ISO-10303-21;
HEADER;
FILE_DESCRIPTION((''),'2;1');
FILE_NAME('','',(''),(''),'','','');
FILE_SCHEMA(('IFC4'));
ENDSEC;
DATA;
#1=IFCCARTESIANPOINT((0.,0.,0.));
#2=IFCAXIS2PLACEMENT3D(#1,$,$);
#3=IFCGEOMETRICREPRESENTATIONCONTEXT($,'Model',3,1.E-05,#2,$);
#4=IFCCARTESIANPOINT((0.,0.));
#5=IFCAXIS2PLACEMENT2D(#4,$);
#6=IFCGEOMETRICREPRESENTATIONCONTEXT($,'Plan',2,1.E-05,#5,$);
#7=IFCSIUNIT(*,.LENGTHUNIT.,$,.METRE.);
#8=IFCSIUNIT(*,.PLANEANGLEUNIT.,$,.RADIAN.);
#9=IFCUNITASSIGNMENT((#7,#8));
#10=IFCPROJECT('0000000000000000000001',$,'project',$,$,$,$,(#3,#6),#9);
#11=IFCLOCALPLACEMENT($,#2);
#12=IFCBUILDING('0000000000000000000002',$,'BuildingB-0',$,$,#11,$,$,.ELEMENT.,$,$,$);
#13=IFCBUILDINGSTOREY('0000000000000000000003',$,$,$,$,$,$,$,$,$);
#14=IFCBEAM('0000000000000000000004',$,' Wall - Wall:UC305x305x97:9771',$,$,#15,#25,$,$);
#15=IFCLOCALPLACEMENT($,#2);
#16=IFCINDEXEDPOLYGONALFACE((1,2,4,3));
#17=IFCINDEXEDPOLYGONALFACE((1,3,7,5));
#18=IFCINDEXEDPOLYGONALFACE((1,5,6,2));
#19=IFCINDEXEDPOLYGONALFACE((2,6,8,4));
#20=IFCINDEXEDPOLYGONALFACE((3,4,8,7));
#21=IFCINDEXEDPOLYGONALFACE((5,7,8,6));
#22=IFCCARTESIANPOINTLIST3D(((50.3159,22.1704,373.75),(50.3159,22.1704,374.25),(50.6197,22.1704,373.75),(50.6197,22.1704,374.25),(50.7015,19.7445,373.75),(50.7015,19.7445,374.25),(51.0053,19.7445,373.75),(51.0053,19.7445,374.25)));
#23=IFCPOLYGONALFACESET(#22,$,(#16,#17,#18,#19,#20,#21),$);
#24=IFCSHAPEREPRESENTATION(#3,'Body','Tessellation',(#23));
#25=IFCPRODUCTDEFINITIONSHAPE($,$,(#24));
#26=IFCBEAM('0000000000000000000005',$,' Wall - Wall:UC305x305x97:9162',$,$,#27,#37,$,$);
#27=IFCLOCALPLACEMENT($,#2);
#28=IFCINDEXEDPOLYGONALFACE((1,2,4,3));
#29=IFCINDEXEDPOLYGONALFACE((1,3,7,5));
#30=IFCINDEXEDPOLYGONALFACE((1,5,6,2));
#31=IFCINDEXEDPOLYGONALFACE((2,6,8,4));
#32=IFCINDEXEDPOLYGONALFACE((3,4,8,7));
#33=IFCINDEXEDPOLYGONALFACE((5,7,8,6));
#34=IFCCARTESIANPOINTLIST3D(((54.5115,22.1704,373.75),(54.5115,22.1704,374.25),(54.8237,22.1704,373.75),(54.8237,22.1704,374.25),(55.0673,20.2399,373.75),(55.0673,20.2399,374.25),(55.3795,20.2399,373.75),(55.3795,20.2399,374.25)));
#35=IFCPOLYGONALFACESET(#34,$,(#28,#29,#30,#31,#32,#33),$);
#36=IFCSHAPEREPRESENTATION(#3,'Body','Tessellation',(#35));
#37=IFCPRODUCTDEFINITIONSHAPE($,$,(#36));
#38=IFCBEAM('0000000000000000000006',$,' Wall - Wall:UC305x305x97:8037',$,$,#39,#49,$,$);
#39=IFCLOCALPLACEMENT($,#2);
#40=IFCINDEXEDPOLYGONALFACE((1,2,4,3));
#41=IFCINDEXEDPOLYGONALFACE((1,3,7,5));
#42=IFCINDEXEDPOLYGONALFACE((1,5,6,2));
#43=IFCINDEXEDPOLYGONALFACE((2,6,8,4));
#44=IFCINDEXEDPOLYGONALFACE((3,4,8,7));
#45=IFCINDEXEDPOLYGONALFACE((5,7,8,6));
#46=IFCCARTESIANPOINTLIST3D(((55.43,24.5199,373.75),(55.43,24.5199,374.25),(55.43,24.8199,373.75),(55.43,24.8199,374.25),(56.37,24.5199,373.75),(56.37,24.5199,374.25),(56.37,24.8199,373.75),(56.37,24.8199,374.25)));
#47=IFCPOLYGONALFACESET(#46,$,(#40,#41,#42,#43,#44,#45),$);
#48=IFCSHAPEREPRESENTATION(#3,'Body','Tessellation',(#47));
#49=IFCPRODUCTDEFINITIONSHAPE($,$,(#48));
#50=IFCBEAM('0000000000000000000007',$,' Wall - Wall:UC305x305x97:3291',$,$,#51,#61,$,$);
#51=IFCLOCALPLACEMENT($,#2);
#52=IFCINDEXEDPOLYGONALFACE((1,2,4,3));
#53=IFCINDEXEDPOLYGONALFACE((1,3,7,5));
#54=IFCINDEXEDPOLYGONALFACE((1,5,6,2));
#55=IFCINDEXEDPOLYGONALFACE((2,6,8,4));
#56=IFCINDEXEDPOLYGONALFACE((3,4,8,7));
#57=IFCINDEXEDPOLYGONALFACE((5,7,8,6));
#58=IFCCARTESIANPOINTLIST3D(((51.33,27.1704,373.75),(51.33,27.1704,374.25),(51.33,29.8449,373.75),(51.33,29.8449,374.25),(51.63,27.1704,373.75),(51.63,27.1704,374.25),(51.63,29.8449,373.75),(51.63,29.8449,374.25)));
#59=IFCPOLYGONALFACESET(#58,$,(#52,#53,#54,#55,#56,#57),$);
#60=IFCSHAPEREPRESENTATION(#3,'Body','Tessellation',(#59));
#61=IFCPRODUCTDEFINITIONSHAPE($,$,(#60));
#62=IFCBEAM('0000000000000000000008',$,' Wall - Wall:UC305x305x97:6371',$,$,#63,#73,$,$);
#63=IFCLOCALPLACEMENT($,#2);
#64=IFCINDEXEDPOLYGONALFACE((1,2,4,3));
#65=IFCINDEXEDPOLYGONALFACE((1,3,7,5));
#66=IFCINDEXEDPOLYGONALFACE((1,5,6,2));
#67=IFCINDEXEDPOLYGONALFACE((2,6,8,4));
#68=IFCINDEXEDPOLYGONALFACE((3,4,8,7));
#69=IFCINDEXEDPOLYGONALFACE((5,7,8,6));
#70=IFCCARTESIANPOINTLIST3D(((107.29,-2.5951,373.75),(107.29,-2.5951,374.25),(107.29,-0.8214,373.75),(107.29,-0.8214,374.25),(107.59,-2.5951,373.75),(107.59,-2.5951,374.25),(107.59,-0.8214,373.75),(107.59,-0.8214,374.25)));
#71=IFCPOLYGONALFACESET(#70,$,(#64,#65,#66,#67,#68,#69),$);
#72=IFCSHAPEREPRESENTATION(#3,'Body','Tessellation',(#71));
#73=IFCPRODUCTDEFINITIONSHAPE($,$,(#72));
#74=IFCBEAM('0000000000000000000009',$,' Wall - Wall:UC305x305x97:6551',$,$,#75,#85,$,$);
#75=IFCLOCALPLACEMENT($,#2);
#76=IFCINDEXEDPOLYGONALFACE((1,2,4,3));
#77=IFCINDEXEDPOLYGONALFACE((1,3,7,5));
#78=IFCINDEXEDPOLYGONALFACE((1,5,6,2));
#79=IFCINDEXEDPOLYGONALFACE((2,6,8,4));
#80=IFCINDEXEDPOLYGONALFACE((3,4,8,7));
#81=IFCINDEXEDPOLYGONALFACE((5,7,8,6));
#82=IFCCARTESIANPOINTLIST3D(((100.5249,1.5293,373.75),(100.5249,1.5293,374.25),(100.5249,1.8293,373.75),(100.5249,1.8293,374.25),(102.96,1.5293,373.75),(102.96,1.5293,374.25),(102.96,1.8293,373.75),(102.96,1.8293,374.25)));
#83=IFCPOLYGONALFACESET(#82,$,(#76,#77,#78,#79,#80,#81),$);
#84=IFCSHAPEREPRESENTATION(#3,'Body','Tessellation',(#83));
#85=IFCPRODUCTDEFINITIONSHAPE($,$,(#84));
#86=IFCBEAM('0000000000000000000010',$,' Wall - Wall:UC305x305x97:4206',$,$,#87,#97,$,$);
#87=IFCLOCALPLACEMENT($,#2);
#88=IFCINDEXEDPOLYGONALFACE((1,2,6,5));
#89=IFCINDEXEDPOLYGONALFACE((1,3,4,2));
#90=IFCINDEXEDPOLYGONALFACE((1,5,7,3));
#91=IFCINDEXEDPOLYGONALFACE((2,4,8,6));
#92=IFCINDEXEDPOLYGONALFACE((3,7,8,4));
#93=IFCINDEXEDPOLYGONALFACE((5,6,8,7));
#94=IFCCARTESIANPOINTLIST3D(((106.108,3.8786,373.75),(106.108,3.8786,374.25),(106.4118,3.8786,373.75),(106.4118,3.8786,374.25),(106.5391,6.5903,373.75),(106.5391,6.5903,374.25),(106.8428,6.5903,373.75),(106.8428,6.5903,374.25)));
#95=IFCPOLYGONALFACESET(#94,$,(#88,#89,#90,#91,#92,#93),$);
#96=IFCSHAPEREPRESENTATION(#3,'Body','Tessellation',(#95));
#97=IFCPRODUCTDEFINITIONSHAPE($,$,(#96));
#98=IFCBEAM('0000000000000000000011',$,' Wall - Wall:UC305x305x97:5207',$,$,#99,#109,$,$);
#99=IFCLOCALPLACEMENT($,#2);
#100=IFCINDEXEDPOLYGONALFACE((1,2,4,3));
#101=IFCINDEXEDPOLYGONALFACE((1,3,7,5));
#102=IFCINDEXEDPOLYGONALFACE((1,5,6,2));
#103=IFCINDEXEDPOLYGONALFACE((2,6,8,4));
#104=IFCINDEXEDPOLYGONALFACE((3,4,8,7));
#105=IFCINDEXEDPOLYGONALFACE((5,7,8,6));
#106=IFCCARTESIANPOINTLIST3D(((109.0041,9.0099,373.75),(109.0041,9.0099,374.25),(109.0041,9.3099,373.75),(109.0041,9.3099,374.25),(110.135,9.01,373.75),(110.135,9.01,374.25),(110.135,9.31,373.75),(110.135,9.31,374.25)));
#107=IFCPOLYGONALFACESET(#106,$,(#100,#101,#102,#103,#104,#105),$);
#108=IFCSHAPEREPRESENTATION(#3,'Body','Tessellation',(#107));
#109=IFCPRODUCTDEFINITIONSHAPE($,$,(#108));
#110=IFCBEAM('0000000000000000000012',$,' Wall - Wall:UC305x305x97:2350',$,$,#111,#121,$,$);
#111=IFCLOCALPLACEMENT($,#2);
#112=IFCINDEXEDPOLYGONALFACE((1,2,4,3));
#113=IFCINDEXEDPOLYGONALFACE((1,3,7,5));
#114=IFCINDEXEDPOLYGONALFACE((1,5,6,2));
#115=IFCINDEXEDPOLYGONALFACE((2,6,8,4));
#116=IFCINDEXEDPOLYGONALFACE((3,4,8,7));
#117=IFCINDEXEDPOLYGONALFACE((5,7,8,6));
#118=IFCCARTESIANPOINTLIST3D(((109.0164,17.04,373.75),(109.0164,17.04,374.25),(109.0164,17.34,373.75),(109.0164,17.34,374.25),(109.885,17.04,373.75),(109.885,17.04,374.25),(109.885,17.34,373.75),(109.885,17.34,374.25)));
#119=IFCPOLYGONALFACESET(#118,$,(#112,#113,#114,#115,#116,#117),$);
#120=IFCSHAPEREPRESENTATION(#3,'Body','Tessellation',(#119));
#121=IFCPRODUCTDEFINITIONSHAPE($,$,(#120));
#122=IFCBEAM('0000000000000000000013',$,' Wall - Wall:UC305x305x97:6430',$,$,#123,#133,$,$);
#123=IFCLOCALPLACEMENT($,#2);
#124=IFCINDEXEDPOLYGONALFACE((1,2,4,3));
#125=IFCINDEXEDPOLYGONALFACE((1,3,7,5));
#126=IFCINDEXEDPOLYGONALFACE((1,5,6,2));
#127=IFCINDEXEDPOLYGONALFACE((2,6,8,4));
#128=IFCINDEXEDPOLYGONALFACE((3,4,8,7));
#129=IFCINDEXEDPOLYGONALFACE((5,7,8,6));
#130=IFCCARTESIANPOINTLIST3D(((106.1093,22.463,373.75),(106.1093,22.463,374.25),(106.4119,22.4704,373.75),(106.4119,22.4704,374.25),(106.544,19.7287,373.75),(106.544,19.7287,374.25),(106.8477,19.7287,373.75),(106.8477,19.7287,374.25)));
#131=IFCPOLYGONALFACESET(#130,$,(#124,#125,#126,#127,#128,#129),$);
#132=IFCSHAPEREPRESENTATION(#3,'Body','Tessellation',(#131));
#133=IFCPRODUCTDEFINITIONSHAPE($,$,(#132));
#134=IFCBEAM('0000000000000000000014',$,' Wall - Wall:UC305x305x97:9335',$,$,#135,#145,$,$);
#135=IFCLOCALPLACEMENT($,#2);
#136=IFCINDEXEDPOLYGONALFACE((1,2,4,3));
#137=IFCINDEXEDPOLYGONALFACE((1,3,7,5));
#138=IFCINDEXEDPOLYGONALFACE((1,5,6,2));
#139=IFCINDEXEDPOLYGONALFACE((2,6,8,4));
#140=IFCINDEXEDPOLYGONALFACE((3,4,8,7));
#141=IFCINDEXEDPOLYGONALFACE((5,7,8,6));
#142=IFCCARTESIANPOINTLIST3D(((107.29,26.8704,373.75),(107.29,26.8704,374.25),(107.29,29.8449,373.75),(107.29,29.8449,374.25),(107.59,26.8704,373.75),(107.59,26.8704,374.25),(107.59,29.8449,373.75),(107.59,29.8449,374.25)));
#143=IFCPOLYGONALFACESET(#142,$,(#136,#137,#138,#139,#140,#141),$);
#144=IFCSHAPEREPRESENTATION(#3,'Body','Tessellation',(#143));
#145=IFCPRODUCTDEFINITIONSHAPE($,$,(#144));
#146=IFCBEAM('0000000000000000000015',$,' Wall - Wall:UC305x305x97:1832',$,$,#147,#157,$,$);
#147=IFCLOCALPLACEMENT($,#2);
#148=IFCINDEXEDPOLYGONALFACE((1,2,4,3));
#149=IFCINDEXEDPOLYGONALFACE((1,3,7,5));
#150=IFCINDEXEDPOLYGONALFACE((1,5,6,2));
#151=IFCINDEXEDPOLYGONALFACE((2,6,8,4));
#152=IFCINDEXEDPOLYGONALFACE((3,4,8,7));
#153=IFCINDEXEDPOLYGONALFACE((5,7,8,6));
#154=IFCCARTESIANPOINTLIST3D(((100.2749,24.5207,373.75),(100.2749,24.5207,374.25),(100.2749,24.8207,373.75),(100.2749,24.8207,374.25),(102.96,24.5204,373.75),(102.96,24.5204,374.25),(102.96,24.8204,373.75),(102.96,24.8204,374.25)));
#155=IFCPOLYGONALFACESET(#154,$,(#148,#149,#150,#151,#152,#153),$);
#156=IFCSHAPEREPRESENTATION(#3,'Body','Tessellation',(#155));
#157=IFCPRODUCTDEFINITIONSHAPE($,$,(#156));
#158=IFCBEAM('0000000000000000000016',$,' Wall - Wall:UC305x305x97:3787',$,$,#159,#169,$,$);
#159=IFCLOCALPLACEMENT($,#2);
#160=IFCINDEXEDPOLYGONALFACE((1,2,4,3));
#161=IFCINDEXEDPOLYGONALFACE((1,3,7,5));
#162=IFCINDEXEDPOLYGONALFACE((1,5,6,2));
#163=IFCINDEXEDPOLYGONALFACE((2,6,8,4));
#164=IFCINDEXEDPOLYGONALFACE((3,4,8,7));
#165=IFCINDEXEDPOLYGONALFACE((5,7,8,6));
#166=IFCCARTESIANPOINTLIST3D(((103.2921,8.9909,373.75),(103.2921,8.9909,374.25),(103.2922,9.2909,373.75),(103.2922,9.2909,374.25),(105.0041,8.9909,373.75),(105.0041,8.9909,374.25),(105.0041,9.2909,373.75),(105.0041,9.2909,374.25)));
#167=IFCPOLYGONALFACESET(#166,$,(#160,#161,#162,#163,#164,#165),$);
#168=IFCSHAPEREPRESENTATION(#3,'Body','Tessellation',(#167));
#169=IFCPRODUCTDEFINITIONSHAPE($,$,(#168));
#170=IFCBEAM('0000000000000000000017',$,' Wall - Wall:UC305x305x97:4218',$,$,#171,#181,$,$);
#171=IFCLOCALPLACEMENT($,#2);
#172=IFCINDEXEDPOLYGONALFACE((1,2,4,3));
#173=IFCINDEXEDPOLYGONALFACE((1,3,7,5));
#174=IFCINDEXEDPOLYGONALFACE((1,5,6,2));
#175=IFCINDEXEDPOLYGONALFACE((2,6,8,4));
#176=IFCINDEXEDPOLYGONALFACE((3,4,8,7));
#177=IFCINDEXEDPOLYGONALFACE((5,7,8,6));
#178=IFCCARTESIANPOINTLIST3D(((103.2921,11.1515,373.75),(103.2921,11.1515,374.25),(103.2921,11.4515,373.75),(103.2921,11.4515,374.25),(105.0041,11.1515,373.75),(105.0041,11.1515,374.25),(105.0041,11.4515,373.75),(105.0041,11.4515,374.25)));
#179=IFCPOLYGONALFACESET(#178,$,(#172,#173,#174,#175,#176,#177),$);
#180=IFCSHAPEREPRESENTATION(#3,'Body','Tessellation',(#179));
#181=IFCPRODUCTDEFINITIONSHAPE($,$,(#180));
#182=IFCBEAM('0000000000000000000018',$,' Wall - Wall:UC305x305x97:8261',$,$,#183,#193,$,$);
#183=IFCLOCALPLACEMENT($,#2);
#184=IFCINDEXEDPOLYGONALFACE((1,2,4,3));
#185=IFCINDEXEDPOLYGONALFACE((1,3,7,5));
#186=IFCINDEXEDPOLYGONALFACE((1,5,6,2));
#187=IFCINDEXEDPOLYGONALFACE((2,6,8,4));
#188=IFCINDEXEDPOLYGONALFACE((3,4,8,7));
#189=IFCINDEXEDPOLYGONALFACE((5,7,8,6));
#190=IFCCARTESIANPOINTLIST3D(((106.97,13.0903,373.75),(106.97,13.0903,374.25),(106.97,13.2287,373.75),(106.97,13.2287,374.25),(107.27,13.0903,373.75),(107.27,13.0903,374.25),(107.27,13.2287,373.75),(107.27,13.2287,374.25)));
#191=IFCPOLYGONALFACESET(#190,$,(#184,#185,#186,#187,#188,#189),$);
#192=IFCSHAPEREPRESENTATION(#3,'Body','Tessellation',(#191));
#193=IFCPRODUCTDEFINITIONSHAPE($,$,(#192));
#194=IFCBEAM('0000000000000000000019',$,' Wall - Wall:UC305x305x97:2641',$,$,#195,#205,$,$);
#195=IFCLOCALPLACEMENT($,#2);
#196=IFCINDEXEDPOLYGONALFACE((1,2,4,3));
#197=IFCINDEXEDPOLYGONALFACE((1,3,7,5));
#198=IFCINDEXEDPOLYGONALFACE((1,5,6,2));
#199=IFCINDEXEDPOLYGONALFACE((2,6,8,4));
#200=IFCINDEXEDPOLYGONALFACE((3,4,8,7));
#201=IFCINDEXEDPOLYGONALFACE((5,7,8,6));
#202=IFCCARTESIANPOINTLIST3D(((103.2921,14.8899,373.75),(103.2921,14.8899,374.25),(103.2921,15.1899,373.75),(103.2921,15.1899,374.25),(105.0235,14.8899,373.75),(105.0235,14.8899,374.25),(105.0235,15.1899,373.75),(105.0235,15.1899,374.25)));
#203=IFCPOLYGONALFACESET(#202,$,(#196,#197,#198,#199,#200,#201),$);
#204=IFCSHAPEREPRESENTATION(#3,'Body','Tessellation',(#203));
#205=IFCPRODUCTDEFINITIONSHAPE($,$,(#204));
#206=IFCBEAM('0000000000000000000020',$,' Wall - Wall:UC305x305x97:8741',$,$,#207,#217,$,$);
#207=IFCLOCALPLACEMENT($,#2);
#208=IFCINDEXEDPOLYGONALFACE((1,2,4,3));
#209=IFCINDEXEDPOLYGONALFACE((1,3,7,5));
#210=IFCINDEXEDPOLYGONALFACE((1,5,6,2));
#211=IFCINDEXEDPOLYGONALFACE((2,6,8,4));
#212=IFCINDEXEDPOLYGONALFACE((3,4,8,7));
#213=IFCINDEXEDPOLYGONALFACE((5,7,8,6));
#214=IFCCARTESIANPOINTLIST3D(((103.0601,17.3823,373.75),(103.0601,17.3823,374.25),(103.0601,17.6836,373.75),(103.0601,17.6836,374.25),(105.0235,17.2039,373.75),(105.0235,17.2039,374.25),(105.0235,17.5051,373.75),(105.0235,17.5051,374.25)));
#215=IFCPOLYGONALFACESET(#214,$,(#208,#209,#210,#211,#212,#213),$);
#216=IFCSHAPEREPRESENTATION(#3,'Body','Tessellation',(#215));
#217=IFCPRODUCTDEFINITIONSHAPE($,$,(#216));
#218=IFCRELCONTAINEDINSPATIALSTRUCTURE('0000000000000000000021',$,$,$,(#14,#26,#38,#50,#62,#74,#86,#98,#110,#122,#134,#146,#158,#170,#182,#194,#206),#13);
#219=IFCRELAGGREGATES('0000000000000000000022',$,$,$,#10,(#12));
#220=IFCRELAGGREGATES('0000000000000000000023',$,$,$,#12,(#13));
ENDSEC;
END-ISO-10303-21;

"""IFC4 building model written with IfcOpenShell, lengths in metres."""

from ifc_helpers import new_model, si_unit, origin, origin_2d, place, context, project, spatial, polyline, outline, extrude, element, save


model = new_model("IFC4")

# Units and contexts
model_context = context("Model", 3, precision=1e-05, world=origin())
plan_context = context("Plan", 2, precision=1e-05, world=origin_2d())
ifc_project = project(units=[si_unit("LENGTHUNIT", "METRE"), si_unit("PLANEANGLEUNIT", "RADIAN")], contexts=[model_context, plan_context])

# Building, storey
building_placement = place(None, origin())
building = spatial("IfcBuilding", under=ifc_project, at=building_placement, Name="BuildingB-0", CompositionType="ELEMENT")
storey = spatial("IfcBuildingStorey", under=building)

# Beams
element("IfcBeam", 1, inside=storey, Name=" Wall - Wall:UC305x305x97:9771", context=model_context, shape_type="SweptSolid", body=[
    extrude(outline(polyline([(50.7015, 19.7445, 373.75), (51.0053, 19.7445, 373.75), (50.6197, 22.1704, 373.75), (50.3159, 22.1704, 373.75), (50.7015, 19.7445, 373.75)])), None, (0.0, 0.0, 1.0), 0.5),
])
element("IfcBeam", 2, inside=storey, Name=" Wall - Wall:UC305x305x97:9162", context=model_context, shape_type="SweptSolid", body=[
    extrude(outline(polyline([(55.0673, 20.2399, 373.75), (55.3795, 20.2399, 373.75), (54.8237, 22.1704, 373.75), (54.5115, 22.1704, 373.75), (55.0673, 20.2399, 373.75)])), None, (0.0, 0.0, 1.0), 0.5),
])
element("IfcBeam", 3, inside=storey, Name=" Wall - Wall:UC305x305x97:8037", context=model_context, shape_type="SweptSolid", body=[
    extrude(outline(polyline([(55.43, 24.5199, 373.75), (55.43, 24.8199, 373.75), (56.37, 24.8199, 373.75), (56.37, 24.5199, 373.75), (55.43, 24.5199, 373.75)])), None, (0.0, 0.0, 1.0), 0.5),
])
element("IfcBeam", 4, inside=storey, Name=" Wall - Wall:UC305x305x97:3291", context=model_context, shape_type="SweptSolid", body=[
    extrude(outline(polyline([(51.33, 27.1704, 373.75), (51.63, 27.1704, 373.75), (51.63, 29.8449, 373.75), (51.33, 29.8449, 373.75), (51.33, 27.1704, 373.75)])), None, (0.0, 0.0, 1.0), 0.5),
])
element("IfcBeam", 5, inside=storey, Name=" Wall - Wall:UC305x305x97:6371", context=model_context, shape_type="SweptSolid", body=[
    extrude(outline(polyline([(107.59, -2.5951, 373.75), (107.29, -2.5951, 373.75), (107.29, -0.8214, 373.75), (107.59, -0.8214, 373.75), (107.59, -2.5951, 373.75)])), None, (0.0, 0.0, 1.0), 0.5),
])
element("IfcBeam", 6, inside=storey, Name=" Wall - Wall:UC305x305x97:6551", context=model_context, shape_type="SweptSolid", body=[
    extrude(outline(polyline([(102.96, 1.5293, 373.75), (102.96, 1.8293, 373.75), (100.5249, 1.8293, 373.75), (100.5249, 1.5293, 373.75), (102.96, 1.5293, 373.75)])), None, (0.0, 0.0, 1.0), 0.5),
])
element("IfcBeam", 7, inside=storey, Name=" Wall - Wall:UC305x305x97:4206", context=model_context, shape_type="SweptSolid", body=[
    extrude(outline(polyline([(106.4118, 3.8786, 373.75), (106.8428, 6.5903, 373.75), (106.5391, 6.5903, 373.75), (106.108, 3.8786, 373.75), (106.4118, 3.8786, 373.75)])), None, (0.0, 0.0, 1.0), 0.5),
])
element("IfcBeam", 8, inside=storey, Name=" Wall - Wall:UC305x305x97:5207", context=model_context, shape_type="SweptSolid", body=[
    extrude(outline(polyline([(110.135, 9.01, 373.75), (110.135, 9.31, 373.75), (109.0041, 9.3099, 373.75), (109.0041, 9.0099, 373.75), (110.135, 9.01, 373.75)])), None, (0.0, 0.0, 1.0), 0.5),
])
element("IfcBeam", 9, inside=storey, Name=" Wall - Wall:UC305x305x97:2350", context=model_context, shape_type="SweptSolid", body=[
    extrude(outline(polyline([(109.885, 17.04, 373.75), (109.885, 17.34, 373.75), (109.0164, 17.34, 373.75), (109.0164, 17.04, 373.75), (109.885, 17.04, 373.75)])), None, (0.0, 0.0, 1.0), 0.5),
])
element("IfcBeam", 10, inside=storey, Name=" Wall - Wall:UC305x305x97:6430", context=model_context, shape_type="SweptSolid", body=[
    extrude(outline(polyline([(106.544, 19.7287, 373.75), (106.8477, 19.7287, 373.75), (106.4119, 22.4704, 373.75), (106.1093, 22.463, 373.75), (106.544, 19.7287, 373.75)])), None, (0.0, 0.0, 1.0), 0.5),
])
element("IfcBeam", 11, inside=storey, Name=" Wall - Wall:UC305x305x97:9335", context=model_context, shape_type="SweptSolid", body=[
    extrude(outline(polyline([(107.29, 26.8704, 373.75), (107.59, 26.8704, 373.75), (107.59, 29.8449, 373.75), (107.29, 29.8449, 373.75), (107.29, 26.8704, 373.75)])), None, (0.0, 0.0, 1.0), 0.5),
])
element("IfcBeam", 12, inside=storey, Name=" Wall - Wall:UC305x305x97:1832", context=model_context, shape_type="SweptSolid", body=[
    extrude(outline(polyline([(102.96, 24.5204, 373.75), (102.96, 24.8204, 373.75), (100.2749, 24.8207, 373.75), (100.2749, 24.5207, 373.75), (102.96, 24.5204, 373.75)])), None, (0.0, 0.0, 1.0), 0.5),
])
element("IfcBeam", 13, inside=storey, Name=" Wall - Wall:UC305x305x97:3787", context=model_context, shape_type="SweptSolid", body=[
    extrude(outline(polyline([(105.0041, 8.9909, 373.75), (105.0041, 9.2909, 373.75), (103.2922, 9.2909, 373.75), (103.2921, 8.9909, 373.75), (105.0041, 8.9909, 373.75)])), None, (0.0, 0.0, 1.0), 0.5),
])
element("IfcBeam", 14, inside=storey, Name=" Wall - Wall:UC305x305x97:4218", context=model_context, shape_type="SweptSolid", body=[
    extrude(outline(polyline([(105.0041, 11.1515, 373.75), (105.0041, 11.4515, 373.75), (103.2921, 11.4515, 373.75), (103.2921, 11.1515, 373.75), (105.0041, 11.1515, 373.75)])), None, (0.0, 0.0, 1.0), 0.5),
])
element("IfcBeam", 15, inside=storey, Name=" Wall - Wall:UC305x305x97:8261", context=model_context, shape_type="SweptSolid", body=[
    extrude(outline(polyline([(107.27, 13.0903, 373.75), (107.27, 13.2287, 373.75), (106.97, 13.2287, 373.75), (106.97, 13.0903, 373.75), (107.27, 13.0903, 373.75)])), None, (0.0, 0.0, 1.0), 0.5),
])
element("IfcBeam", 16, inside=storey, Name=" Wall - Wall:UC305x305x97:2641", context=model_context, shape_type="SweptSolid", body=[
    extrude(outline(polyline([(105.0235, 14.8899, 373.75), (105.0235, 15.1899, 373.75), (103.2921, 15.1899, 373.75), (103.2921, 14.8899, 373.75), (105.0235, 14.8899, 373.75)])), None, (0.0, 0.0, 1.0), 0.5),
])
element("IfcBeam", 17, inside=storey, Name=" Wall - Wall:UC305x305x97:8741", context=model_context, shape_type="SweptSolid", body=[
    extrude(outline(polyline([(105.0235, 17.2039, 373.75), (105.0235, 17.5051, 373.75), (103.0601, 17.6836, 373.75), (103.0601, 17.3823, 373.75), (105.0235, 17.2039, 373.75)])), None, (0.0, 0.0, 1.0), 0.5),
])

save(model, "model.ifc")
